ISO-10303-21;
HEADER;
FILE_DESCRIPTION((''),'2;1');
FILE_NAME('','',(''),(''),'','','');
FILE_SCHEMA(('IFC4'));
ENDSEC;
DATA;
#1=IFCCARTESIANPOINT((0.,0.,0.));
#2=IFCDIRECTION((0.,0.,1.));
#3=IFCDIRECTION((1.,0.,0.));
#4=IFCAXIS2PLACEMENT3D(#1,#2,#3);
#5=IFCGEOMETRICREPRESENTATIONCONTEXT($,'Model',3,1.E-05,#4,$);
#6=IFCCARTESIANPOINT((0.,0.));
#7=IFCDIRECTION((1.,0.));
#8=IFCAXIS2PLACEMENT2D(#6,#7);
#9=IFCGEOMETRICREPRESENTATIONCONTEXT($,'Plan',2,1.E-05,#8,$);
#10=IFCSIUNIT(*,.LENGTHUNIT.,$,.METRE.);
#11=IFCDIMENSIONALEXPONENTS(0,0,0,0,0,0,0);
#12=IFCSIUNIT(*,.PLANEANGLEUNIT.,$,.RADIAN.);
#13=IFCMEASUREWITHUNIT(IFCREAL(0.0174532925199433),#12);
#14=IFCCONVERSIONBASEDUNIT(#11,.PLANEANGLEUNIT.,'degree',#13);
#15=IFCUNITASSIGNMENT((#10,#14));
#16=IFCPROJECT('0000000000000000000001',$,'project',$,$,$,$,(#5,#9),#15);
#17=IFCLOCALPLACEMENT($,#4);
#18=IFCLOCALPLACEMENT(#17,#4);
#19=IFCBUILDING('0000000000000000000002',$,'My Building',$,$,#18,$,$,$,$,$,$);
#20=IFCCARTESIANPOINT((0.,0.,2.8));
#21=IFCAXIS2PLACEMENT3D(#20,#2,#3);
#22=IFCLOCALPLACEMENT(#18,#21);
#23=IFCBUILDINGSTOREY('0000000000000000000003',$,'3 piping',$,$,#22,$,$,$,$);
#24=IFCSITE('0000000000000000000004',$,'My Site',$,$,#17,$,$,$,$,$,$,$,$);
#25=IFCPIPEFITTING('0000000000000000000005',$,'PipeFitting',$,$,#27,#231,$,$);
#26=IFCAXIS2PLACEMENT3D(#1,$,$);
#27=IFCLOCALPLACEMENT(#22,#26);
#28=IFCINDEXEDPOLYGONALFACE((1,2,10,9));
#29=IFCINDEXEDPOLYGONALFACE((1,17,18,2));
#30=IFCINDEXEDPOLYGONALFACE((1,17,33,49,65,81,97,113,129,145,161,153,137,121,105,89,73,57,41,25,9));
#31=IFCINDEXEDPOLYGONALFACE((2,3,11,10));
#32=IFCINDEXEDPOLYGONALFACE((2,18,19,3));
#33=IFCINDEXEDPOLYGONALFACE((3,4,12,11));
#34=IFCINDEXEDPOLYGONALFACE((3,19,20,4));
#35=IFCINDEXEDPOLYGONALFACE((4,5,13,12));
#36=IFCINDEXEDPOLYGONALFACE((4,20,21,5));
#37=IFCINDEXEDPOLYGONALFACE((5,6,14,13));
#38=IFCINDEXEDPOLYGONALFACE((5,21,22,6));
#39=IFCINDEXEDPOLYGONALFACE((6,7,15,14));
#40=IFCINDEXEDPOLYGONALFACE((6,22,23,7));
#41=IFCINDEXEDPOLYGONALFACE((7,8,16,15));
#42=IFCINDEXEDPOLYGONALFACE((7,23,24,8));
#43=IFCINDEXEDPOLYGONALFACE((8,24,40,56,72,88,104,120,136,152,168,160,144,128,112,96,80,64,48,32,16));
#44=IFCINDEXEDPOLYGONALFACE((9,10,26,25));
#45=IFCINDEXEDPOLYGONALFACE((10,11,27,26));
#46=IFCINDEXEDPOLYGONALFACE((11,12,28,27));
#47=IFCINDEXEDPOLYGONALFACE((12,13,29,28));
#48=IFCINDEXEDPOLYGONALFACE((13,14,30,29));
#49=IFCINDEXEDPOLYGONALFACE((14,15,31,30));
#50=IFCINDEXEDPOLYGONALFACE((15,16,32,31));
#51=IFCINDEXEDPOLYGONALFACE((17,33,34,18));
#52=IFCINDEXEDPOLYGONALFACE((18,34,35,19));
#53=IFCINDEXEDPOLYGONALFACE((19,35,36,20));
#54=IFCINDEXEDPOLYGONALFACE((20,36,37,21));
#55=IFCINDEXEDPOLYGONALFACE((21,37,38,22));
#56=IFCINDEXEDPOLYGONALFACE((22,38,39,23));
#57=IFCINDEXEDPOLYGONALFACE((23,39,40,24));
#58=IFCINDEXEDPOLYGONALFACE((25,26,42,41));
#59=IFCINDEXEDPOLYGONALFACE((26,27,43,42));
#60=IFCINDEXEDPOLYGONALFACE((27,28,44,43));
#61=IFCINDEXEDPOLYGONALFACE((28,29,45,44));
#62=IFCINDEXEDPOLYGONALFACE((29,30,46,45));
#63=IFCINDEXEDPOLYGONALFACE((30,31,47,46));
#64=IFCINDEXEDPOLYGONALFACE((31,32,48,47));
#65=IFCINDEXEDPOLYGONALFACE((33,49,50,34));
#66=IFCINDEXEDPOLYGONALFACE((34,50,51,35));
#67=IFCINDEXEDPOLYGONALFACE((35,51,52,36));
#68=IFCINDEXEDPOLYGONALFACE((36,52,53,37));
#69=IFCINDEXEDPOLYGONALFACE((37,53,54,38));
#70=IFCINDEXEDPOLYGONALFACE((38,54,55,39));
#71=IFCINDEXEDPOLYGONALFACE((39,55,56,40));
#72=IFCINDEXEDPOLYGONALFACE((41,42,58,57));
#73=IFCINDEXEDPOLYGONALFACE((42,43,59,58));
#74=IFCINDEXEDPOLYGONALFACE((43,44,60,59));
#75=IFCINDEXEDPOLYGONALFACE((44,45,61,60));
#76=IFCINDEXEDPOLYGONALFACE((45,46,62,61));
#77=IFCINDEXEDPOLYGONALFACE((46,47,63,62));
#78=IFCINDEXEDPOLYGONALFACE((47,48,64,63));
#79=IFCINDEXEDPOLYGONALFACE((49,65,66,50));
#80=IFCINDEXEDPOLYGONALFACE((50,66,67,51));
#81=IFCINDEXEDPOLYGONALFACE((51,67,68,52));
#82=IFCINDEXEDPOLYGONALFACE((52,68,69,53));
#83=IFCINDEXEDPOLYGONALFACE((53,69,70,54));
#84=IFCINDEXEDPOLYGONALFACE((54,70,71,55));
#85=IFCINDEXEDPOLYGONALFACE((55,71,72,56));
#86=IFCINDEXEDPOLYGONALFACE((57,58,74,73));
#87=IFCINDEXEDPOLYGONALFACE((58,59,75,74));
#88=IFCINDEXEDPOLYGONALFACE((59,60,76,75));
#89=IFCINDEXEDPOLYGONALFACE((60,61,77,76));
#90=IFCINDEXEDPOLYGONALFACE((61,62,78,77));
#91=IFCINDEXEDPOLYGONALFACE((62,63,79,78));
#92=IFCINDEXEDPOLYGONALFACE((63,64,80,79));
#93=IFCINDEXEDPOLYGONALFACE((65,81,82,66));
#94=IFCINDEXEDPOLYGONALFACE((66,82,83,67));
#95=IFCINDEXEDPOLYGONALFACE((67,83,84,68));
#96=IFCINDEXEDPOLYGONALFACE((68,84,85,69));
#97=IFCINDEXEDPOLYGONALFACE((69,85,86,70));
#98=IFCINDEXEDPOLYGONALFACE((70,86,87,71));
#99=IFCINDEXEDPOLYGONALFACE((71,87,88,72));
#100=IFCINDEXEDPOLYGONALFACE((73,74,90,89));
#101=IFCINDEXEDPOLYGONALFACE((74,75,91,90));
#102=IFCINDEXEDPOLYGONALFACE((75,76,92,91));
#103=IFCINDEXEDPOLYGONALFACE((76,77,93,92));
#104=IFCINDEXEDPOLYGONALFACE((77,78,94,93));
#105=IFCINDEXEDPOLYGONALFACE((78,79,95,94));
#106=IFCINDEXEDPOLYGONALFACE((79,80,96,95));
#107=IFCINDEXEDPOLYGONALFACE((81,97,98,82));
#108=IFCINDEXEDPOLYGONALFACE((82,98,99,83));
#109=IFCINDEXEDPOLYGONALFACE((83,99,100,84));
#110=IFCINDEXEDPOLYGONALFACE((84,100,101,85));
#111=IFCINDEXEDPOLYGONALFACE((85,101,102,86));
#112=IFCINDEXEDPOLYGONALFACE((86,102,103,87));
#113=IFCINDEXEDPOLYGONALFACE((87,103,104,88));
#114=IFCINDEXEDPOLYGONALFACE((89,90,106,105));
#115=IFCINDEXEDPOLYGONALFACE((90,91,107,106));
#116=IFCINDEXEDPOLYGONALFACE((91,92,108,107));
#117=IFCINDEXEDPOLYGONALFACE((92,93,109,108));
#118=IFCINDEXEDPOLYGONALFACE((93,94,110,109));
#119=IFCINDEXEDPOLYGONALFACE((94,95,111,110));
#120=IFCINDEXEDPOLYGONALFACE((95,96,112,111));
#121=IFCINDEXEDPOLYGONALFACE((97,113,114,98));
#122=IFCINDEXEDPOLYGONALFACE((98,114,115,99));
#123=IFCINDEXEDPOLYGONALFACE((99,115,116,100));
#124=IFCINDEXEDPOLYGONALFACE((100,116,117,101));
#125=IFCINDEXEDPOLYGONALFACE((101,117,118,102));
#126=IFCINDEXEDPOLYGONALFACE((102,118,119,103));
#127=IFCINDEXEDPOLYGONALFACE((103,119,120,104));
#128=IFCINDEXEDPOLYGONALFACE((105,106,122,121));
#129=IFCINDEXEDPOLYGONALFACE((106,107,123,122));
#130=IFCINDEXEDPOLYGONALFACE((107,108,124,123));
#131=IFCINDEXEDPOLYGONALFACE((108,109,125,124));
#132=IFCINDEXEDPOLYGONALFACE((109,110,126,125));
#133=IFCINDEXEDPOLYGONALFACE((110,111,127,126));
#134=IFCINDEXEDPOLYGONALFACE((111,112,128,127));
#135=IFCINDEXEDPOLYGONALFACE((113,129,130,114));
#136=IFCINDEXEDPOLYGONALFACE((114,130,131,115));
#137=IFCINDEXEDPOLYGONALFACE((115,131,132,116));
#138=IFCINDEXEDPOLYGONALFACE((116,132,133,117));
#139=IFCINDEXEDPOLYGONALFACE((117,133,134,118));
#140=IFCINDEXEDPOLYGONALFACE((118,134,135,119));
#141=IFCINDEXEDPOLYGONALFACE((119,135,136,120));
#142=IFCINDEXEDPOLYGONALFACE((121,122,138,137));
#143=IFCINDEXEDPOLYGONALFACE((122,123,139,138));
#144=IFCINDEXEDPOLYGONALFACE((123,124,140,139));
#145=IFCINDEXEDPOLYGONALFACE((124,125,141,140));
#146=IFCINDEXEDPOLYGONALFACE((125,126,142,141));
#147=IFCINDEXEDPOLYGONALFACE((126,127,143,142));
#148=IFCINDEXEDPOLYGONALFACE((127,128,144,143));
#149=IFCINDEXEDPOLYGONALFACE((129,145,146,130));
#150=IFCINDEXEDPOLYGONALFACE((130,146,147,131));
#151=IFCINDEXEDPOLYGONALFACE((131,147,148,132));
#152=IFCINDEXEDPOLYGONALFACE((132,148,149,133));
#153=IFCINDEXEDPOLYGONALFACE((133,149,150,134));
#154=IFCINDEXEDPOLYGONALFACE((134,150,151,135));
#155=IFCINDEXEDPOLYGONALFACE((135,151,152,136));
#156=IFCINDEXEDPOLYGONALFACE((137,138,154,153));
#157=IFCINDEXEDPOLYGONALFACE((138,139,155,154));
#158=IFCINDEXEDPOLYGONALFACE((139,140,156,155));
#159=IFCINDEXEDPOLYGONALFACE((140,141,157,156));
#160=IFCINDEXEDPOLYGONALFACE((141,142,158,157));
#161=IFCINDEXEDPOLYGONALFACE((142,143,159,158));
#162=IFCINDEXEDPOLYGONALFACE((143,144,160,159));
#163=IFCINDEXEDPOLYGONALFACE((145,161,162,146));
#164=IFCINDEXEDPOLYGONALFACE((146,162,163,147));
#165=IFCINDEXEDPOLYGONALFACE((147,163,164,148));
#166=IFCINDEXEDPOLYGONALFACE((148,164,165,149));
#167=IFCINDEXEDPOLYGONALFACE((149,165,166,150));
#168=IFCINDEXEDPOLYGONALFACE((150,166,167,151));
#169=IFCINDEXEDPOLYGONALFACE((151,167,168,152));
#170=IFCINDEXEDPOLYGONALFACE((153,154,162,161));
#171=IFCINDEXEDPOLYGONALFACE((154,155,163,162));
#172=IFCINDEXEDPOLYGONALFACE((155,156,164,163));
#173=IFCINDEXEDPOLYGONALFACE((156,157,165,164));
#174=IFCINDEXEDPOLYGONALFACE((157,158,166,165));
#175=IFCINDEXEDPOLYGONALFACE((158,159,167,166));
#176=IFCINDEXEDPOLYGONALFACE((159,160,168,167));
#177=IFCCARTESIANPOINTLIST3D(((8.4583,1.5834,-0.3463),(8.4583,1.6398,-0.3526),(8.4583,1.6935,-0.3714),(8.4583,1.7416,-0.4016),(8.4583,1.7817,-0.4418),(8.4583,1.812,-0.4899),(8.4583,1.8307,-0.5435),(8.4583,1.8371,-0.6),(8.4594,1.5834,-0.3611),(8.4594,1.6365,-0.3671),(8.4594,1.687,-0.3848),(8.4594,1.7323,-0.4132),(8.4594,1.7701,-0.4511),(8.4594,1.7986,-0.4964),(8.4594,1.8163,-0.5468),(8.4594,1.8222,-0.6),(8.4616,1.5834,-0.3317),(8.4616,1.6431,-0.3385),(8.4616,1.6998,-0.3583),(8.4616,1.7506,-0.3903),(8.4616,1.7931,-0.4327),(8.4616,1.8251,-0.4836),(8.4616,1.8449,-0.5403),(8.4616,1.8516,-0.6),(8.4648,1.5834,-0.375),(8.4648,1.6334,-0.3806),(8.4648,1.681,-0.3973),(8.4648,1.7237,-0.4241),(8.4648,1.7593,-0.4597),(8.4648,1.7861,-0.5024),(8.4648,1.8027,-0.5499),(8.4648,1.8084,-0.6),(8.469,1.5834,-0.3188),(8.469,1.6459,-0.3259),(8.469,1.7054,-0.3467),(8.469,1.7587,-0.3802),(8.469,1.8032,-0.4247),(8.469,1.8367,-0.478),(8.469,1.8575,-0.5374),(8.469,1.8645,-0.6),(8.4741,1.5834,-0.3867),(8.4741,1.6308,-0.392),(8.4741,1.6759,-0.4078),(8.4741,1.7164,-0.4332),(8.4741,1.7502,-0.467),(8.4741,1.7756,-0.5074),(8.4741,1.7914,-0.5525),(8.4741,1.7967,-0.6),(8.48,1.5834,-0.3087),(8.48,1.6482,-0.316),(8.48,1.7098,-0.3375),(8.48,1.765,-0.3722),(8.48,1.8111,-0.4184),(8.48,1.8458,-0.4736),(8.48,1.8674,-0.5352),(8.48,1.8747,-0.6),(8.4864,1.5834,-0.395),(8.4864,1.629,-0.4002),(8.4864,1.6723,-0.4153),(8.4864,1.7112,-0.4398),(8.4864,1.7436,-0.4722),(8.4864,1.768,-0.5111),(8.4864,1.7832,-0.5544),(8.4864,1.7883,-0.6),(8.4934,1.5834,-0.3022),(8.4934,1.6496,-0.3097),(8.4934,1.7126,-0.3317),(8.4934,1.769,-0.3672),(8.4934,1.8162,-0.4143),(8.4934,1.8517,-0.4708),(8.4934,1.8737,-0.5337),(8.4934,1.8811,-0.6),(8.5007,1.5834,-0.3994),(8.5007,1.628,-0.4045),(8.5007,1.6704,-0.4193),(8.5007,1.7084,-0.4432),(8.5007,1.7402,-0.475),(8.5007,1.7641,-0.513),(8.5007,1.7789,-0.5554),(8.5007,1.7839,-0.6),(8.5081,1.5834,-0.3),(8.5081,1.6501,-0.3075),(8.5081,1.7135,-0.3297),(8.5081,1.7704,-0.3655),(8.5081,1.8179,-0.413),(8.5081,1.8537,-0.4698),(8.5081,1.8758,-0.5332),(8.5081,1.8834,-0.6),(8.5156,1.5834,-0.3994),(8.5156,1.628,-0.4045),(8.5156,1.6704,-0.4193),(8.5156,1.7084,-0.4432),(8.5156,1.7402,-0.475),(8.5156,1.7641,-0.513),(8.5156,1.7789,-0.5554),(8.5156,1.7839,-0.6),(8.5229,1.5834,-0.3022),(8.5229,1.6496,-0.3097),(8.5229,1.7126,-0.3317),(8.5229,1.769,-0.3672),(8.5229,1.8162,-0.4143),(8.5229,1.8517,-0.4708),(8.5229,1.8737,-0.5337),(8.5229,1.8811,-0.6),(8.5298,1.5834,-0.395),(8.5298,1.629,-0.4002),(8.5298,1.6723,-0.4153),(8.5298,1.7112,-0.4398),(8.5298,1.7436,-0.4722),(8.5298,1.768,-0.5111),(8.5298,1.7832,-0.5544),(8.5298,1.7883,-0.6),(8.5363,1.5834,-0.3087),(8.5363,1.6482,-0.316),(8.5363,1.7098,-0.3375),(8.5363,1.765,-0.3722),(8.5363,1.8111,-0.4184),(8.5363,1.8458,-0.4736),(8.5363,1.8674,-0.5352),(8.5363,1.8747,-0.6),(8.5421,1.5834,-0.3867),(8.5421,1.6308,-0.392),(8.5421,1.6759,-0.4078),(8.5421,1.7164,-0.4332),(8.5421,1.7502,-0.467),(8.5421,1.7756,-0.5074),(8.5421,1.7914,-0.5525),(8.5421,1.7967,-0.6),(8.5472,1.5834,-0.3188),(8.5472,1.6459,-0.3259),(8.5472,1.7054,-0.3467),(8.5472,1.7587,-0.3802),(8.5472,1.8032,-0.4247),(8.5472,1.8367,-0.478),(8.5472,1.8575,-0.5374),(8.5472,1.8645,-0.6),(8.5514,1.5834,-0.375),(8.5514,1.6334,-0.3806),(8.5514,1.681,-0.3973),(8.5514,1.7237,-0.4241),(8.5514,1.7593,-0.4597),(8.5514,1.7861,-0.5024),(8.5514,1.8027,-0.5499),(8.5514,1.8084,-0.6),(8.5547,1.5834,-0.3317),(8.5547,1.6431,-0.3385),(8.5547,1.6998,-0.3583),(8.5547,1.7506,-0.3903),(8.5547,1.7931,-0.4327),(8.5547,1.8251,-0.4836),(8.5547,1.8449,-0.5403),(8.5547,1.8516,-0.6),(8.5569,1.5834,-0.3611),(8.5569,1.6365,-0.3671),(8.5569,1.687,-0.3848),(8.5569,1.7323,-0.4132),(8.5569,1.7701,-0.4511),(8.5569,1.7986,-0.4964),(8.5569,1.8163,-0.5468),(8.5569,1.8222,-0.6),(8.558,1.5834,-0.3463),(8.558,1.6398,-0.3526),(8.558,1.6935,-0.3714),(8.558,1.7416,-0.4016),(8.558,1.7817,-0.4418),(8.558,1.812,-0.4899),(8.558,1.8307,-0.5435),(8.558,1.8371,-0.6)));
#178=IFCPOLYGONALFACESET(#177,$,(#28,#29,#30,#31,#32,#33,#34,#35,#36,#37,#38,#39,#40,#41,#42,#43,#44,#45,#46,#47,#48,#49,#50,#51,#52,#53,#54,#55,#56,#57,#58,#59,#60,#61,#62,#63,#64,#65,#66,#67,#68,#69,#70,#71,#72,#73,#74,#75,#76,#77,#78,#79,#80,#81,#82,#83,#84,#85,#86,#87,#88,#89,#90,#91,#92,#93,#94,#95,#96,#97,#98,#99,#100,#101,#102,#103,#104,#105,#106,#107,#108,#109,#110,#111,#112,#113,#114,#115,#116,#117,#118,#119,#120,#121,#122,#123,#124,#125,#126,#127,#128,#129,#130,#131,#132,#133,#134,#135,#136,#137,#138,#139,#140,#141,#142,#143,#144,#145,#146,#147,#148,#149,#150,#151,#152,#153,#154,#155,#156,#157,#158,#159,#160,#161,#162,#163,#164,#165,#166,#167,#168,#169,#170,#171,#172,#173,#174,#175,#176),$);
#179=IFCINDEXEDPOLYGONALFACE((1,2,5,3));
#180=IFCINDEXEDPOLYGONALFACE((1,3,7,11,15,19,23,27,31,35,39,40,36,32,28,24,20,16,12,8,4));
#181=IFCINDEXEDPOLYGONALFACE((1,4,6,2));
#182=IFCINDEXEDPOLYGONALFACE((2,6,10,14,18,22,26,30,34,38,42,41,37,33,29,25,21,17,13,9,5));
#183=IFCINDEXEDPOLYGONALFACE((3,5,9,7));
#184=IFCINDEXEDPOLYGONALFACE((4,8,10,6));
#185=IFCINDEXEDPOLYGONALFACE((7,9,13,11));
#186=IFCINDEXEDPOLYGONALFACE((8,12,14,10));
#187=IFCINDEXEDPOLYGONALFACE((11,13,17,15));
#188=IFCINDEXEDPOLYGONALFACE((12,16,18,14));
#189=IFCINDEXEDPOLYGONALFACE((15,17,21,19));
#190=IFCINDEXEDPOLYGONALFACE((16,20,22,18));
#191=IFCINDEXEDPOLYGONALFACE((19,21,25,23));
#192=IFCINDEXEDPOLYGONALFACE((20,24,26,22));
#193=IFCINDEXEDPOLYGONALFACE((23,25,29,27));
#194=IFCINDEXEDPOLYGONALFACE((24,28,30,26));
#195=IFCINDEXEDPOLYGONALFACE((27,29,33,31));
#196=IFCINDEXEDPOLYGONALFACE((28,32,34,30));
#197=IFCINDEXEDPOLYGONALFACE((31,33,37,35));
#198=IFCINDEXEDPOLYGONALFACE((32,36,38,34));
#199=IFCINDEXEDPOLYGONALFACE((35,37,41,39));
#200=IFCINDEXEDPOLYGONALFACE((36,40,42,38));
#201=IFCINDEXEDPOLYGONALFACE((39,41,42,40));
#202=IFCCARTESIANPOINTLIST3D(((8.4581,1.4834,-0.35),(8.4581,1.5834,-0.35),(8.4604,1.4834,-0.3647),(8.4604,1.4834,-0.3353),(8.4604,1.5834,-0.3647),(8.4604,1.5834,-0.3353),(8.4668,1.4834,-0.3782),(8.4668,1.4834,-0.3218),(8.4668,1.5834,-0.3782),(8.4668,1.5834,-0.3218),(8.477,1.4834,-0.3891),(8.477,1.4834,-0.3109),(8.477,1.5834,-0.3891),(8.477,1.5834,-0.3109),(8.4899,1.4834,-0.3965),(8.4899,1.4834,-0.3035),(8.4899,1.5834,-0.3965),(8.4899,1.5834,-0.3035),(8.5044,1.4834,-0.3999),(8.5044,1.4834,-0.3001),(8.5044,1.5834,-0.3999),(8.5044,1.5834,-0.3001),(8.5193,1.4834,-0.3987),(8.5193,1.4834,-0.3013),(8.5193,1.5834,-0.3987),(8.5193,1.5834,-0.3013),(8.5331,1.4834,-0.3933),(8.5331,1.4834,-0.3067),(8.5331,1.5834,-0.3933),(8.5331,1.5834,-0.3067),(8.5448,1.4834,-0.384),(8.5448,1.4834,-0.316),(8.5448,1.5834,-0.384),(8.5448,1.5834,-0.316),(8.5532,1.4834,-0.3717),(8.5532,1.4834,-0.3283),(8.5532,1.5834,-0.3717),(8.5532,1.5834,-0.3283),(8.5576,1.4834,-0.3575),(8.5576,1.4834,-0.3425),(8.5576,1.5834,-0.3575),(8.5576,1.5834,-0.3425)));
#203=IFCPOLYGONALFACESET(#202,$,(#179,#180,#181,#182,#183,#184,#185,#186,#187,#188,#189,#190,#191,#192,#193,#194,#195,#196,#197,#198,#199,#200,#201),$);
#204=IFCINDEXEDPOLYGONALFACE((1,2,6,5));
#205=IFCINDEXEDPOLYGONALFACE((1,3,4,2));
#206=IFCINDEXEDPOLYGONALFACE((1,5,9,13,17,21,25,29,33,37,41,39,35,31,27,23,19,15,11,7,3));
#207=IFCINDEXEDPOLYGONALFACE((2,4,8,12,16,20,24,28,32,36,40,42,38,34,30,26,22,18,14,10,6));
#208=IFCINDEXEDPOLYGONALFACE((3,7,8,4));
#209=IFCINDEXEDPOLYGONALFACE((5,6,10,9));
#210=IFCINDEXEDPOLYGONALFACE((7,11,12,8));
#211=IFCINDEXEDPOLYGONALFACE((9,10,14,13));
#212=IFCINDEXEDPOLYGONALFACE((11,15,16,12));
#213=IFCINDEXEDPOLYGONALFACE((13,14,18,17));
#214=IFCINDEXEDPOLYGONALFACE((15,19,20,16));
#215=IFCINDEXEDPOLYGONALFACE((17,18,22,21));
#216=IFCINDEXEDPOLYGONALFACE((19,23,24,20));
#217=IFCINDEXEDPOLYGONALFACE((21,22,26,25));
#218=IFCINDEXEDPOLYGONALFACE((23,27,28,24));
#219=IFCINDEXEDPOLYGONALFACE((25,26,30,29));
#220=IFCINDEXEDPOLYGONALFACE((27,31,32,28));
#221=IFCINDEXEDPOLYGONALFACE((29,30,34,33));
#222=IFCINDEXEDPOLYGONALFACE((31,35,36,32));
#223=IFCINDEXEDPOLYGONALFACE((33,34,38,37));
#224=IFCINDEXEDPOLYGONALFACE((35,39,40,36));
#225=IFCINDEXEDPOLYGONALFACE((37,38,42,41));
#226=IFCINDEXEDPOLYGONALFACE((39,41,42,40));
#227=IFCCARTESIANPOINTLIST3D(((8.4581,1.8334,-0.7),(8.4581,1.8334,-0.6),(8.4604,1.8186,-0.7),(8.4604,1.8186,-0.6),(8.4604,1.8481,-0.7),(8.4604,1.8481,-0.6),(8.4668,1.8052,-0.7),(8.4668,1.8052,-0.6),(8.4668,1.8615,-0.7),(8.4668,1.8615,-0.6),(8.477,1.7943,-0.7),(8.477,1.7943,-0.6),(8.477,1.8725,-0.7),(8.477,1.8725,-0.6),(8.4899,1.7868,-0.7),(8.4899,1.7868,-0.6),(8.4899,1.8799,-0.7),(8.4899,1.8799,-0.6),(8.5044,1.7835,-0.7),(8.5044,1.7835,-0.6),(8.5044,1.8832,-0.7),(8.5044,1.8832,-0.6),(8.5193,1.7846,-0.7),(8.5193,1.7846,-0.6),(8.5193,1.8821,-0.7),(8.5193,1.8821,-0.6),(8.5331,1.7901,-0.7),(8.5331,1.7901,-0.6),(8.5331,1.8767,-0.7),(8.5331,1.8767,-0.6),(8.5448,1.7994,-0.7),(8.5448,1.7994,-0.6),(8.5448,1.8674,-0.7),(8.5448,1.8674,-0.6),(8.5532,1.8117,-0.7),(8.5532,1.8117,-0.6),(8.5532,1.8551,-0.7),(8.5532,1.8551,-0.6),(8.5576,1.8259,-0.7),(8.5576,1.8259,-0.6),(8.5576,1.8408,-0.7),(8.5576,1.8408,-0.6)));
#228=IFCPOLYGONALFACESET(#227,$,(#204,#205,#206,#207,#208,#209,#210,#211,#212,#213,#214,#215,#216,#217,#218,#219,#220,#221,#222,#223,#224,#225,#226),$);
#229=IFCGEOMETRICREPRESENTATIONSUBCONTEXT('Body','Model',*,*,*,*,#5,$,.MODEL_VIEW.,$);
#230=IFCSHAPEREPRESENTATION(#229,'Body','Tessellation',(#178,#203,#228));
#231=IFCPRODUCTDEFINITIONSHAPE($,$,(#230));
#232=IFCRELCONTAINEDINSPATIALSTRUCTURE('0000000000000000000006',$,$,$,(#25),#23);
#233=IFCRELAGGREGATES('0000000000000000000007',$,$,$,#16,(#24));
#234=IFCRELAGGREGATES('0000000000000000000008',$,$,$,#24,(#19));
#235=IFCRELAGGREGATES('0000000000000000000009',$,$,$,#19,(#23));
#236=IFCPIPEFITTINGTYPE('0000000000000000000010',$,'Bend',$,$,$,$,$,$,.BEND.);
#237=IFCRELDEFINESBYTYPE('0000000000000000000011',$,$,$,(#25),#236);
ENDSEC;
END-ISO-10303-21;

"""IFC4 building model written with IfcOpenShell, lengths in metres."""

from ifc_helpers import new_model, entity, si_unit, converted_unit, frame, origin_with_axes, origin_2d_with_axis, place, context, subcontext, project, spatial, circle, extrude, source, transform, mapped, type_object, type_shapes, element, save


model = new_model("IFC4")

# Units and contexts
model_context = context("Model", 3, precision=1e-05, world=origin_with_axes())
plan_context = context("Plan", 2, precision=1e-05, world=origin_2d_with_axis())
body_context = subcontext(model_context, "Body", "Model", "MODEL_VIEW")
ifc_project = project(units=[si_unit("LENGTHUNIT", "METRE"), converted_unit("PLANEANGLEUNIT", "degree", entity("IfcReal", 0.0174532925199433), si_unit("PLANEANGLEUNIT", "RADIAN"), dimensions=[0, 0, 0, 0, 0, 0, 0])], contexts=[model_context, plan_context])

# Site, building, storey
site_placement = place(None, origin_with_axes())
site = spatial("IfcSite", under=ifc_project, at=site_placement, Name="My Site")
building_placement = place(site_placement, origin_with_axes())
building = spatial("IfcBuilding", under=site, at=building_placement, Name="My Building")
storey_placement = place(building_placement, frame((0.0, 0.0, 2.8), z_axis=(0.0, 0.0, 1.0), x_axis=(1.0, 0.0, 0.0)))
storey = spatial("IfcBuildingStorey", under=building, at=storey_placement, Name="3 piping")

# Pipe fitting
pipe_fitting_type_1 = type_object("IfcPipeFittingType", Name="Bend", PredefinedType="BEND")
shared_shape = source(origin_with_axes(), body_context, "Body", "SolidModel", [
    entity("IfcSweptDiskSolid", entity("IfcIndexedPolyCurve", entity("IfcCartesianPointList3D", [[0.0, 0.0, 0.1], [0.0, -0.0732, 0.2768], [0.0, -0.25, 0.35]]), [entity("IfcArcIndex", [1, 2, 3])]), 0.05),
    extrude(circle(Radius=0.05), origin_with_axes(), (0.0, 0.0, 1.0), 0.1),
    extrude(circle(Radius=0.05), frame((0.0, -0.25, 0.35), z_axis=(0.0, -1.0, 0.0), x_axis=(1.0, 0.0, 0.0)), (0.0, 0.0, 1.0), 0.1),
])
type_shapes(pipe_fitting_type_1, [shared_shape])
for number, where, z_axis, x_axis, name in (
    (1, (8.5081, 1.4834, -0.35), (0.0, 1.0, 0.0), (-1.0, 0.0, 0.0), "PipeFitting"),
):
    element("IfcPipeFitting", number, at=place(storey_placement, frame(where, z_axis=z_axis, x_axis=x_axis)), inside=storey, type_object=pipe_fitting_type_1, Name=name, context=body_context, shape_type="MappedRepresentation", body=[
        mapped(shared_shape, transform((0.0, 0.0, 0.0), x_axis=(1.0, 0.0, 0.0), y_axis=(0.0, 1.0, 0.0), z_axis=(0.0, 0.0, 1.0), scale=1.0)),
    ])

save(model, "model.ifc")
